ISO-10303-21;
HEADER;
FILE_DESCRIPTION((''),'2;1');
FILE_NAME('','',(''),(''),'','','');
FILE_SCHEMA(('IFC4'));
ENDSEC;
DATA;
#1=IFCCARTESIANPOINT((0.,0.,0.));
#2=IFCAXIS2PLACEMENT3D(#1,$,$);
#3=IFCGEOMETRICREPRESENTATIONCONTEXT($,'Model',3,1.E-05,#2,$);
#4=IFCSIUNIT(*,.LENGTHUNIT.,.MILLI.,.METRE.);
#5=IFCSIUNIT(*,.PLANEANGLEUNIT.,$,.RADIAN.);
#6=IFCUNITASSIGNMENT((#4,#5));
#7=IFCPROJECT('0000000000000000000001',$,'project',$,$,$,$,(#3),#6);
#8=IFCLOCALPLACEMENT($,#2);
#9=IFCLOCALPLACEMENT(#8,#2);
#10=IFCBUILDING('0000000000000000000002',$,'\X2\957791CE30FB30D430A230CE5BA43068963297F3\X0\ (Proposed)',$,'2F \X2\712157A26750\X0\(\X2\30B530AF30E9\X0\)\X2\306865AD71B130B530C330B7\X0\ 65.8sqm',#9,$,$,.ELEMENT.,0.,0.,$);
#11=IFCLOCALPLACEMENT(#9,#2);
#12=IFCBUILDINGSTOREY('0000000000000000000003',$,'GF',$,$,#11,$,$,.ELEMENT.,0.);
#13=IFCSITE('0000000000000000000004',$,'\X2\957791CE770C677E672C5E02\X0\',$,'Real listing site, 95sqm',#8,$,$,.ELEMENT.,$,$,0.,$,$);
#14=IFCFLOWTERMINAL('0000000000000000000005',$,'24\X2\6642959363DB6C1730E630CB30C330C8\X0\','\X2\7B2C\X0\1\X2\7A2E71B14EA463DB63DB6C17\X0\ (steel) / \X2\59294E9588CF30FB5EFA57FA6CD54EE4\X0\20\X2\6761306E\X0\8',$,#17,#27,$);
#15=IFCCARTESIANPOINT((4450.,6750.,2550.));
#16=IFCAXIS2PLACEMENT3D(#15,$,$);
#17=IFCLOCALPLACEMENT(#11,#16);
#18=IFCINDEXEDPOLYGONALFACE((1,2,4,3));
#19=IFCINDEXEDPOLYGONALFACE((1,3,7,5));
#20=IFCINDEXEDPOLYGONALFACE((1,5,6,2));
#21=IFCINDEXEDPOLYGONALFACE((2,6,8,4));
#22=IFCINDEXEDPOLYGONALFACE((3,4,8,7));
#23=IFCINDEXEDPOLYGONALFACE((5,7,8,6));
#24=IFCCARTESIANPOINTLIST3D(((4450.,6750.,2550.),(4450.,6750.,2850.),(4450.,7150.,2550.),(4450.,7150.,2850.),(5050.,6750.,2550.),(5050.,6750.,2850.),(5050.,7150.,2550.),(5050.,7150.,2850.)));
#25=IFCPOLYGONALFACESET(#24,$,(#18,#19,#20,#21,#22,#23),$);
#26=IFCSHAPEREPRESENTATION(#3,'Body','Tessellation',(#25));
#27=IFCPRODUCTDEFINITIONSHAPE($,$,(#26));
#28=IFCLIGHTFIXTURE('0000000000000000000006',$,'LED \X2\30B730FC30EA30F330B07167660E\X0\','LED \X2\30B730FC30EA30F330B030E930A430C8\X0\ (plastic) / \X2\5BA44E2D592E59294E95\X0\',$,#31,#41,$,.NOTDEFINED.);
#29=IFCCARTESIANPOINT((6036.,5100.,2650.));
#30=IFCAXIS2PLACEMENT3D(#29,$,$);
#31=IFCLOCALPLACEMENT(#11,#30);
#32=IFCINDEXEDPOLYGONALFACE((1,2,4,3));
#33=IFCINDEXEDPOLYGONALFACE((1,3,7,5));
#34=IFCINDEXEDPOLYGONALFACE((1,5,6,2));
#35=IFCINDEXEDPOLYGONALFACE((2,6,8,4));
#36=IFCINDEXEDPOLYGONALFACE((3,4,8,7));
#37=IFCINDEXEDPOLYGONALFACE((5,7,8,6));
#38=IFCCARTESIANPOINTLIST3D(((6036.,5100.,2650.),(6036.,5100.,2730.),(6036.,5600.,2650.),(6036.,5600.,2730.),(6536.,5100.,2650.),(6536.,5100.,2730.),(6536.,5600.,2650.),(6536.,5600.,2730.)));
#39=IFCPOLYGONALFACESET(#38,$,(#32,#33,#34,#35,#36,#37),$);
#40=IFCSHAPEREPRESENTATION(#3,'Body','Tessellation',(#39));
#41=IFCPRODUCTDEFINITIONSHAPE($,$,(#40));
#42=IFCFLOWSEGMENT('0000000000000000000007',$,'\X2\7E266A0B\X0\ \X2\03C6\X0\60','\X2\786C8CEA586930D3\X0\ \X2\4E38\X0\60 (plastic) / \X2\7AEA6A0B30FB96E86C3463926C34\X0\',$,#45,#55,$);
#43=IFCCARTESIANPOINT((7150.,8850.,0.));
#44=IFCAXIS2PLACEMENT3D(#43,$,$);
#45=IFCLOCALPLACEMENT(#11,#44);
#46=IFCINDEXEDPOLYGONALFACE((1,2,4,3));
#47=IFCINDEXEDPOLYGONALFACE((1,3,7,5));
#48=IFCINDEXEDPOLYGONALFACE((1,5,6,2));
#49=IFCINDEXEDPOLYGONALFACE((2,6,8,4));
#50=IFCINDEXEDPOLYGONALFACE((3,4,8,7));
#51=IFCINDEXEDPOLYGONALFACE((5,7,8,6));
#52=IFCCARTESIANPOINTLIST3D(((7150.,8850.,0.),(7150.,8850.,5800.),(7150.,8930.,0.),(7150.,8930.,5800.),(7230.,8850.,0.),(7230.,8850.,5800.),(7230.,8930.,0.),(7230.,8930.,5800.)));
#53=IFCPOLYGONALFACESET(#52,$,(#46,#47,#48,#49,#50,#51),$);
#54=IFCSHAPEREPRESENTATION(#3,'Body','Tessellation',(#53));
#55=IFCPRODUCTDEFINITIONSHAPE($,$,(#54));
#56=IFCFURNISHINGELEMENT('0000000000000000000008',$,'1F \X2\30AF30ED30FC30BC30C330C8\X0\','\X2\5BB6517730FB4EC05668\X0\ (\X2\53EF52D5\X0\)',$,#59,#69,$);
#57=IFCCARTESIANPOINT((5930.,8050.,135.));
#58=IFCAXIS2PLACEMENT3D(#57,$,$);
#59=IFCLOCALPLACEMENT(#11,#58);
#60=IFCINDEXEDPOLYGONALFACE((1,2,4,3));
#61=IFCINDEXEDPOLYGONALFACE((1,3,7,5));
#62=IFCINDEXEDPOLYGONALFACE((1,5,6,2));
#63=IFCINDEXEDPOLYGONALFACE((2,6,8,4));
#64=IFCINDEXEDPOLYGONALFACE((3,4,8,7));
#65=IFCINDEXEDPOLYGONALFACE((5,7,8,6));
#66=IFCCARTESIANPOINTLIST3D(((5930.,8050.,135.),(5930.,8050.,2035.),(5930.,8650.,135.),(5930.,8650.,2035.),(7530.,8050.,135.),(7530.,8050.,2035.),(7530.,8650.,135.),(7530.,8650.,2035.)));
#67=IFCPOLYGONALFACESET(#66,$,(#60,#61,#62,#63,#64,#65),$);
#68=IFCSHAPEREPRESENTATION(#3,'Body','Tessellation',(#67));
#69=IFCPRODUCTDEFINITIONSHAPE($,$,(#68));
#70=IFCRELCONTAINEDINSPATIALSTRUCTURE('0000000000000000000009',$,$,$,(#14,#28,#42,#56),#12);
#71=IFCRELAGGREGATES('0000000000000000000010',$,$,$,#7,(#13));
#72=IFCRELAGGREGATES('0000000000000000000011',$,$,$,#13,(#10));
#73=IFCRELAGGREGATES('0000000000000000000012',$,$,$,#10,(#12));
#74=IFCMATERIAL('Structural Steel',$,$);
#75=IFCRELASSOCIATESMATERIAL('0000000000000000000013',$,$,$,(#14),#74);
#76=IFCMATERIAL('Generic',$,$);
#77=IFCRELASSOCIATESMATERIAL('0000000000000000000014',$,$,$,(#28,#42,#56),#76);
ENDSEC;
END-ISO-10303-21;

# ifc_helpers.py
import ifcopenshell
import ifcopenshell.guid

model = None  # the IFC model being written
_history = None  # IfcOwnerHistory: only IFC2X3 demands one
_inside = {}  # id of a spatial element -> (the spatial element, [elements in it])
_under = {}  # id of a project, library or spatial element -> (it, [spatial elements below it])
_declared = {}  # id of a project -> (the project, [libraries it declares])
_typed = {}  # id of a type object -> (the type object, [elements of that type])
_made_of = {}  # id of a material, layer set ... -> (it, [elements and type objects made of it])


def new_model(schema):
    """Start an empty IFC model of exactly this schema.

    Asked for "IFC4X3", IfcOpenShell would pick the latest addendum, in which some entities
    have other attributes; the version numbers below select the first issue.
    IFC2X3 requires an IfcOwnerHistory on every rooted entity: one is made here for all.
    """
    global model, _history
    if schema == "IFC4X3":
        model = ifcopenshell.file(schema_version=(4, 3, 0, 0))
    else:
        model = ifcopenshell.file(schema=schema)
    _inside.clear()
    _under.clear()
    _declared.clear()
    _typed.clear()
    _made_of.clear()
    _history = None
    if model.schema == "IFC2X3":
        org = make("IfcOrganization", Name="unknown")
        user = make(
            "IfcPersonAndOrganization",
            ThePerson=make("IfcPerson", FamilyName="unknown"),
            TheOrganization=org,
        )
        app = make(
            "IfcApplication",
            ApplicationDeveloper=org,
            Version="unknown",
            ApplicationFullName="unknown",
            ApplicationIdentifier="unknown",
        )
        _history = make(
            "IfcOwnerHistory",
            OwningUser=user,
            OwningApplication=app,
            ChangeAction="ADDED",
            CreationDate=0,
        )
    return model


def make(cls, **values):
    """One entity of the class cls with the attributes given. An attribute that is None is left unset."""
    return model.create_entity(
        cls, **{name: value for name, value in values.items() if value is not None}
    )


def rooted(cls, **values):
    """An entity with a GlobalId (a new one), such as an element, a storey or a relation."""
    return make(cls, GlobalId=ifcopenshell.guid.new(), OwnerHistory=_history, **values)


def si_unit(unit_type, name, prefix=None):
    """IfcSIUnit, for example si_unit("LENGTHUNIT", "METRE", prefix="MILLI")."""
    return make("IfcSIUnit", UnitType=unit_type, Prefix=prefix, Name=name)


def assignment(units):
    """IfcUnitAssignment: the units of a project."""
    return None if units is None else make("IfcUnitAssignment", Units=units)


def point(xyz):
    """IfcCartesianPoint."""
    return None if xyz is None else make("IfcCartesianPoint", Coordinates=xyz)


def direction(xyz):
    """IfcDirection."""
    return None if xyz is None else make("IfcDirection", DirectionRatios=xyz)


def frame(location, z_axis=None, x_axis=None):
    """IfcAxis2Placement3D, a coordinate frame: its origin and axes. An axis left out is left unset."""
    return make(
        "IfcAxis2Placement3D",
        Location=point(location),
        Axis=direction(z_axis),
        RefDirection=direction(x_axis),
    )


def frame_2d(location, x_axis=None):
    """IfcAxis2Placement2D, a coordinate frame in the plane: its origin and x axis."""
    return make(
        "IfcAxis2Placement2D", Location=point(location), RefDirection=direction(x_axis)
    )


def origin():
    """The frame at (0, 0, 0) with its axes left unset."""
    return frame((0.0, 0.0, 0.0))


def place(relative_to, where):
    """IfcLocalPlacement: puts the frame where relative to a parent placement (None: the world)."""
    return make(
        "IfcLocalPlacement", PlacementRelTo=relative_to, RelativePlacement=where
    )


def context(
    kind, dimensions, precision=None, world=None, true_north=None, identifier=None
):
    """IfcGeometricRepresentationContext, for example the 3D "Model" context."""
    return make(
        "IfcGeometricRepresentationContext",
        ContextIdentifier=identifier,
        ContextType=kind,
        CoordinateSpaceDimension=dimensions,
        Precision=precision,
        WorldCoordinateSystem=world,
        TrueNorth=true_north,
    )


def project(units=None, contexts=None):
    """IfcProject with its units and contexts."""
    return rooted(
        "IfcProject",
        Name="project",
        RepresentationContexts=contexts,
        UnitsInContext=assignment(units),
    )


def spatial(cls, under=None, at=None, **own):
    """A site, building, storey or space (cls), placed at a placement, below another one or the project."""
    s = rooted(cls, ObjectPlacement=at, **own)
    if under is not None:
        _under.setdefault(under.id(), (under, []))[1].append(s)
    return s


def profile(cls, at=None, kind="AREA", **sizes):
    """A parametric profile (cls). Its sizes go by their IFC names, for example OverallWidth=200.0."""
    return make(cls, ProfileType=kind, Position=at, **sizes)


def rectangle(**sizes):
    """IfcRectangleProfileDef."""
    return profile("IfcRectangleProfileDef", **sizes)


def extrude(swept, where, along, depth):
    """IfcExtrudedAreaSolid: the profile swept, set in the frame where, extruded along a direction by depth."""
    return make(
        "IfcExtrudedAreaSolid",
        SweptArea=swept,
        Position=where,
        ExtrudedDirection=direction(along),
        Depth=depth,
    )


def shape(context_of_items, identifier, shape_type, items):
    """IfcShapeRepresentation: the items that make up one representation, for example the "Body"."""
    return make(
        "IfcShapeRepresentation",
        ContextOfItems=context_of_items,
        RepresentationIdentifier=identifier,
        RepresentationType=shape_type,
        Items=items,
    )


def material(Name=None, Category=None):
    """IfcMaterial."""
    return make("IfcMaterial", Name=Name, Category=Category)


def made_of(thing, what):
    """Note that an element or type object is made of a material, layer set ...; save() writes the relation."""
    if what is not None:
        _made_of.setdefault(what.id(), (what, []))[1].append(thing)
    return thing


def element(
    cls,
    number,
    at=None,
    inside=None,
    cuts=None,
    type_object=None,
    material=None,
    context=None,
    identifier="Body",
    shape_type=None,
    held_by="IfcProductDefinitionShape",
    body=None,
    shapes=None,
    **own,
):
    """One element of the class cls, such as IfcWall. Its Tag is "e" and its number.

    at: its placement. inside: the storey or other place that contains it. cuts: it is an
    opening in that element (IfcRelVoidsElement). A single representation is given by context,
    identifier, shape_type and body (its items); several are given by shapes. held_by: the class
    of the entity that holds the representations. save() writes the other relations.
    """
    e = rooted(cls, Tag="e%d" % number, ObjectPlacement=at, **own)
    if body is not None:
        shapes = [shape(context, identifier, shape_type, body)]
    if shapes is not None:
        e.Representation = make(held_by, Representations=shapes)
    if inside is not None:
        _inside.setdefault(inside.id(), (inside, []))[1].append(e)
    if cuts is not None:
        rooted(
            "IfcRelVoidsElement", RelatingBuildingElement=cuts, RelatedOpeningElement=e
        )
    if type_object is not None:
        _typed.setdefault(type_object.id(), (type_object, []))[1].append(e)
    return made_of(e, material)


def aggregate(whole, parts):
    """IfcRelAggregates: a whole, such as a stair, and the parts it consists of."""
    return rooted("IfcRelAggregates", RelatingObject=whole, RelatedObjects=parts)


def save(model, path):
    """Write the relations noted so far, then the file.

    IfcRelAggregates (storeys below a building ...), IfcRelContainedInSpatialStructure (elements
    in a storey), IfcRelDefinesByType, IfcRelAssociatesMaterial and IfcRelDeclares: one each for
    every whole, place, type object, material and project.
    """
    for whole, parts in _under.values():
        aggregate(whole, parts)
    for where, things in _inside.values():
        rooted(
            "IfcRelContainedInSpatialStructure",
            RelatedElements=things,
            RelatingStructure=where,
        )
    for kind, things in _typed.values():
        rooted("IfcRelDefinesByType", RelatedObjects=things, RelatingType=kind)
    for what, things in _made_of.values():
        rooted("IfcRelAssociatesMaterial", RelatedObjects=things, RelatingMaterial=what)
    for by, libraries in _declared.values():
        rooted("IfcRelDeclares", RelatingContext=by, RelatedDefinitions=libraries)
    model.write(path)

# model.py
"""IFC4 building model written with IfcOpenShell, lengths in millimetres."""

from ifc_helpers import new_model, si_unit, frame, frame_2d, origin, place, context, project, spatial, rectangle, extrude, material, element, save


model = new_model("IFC4")

# Units and contexts
model_context = context("Model", 3, precision=1e-05, world=origin())
ifc_project = project(units=[si_unit("LENGTHUNIT", "METRE", prefix="MILLI"), si_unit("PLANEANGLEUNIT", "RADIAN")], contexts=[model_context])

# Site, building, storey
site_placement = place(None, origin())
site = spatial("IfcSite", under=ifc_project, at=site_placement, Name="長野県松本市", ObjectType="Real listing site, 95sqm", CompositionType="ELEMENT", RefElevation=0.0)
building_placement = place(site_placement, origin())
building = spatial("IfcBuilding", under=site, at=building_placement, Name="長野・ピアノ室と防音 (Proposed)", ObjectType="2F 無垢材(サクラ)と断熱サッシ 65.8sqm", CompositionType="ELEMENT", ElevationOfRefHeight=0.0, ElevationOfTerrain=0.0)
storey_placement = place(building_placement, origin())
storey = spatial("IfcBuildingStorey", under=building, at=storey_placement, Name="GF", CompositionType="ELEMENT", Elevation=0.0)

# Shared definitions
ifc_material_1 = material(Name="Generic")

# Flow terminal
ifc_material_2 = material(Name="Structural Steel")
flow_terminal_placement = place(storey_placement, frame((4450.0, 6750.0, 2550.0)))
element("IfcFlowTerminal", 1, at=flow_terminal_placement, inside=storey, material=ifc_material_2, Name="24時間換気ユニット", Description="第1種熱交換換気 (steel) / 天井裏・建基法令20条の8", context=model_context, shape_type="SweptSolid", body=[
    extrude(rectangle(XDim=600.0, YDim=400.0, at=frame_2d((300.0, 200.0))), frame((4450.0, 6750.0, 2550.0)), (0.0, 0.0, 1.0), 300.0),
])

# Light fixture
light_fixture_placement = place(storey_placement, frame((6036.0, 5100.0, 2650.0)))
element("IfcLightFixture", 2, at=light_fixture_placement, inside=storey, material=ifc_material_1, Name="LED シーリング照明", Description="LED シーリングライト (plastic) / 室中央天井", PredefinedType="NOTDEFINED", context=model_context, shape_type="SweptSolid", body=[
    extrude(rectangle(XDim=500.0, YDim=500.0, at=frame_2d((250.0, 250.0))), frame((6036.0, 5100.0, 2650.0)), (0.0, 0.0, 1.0), 80.0),
])

# Flow segment
flow_segment_placement = place(storey_placement, frame((7150.0, 8850.0, 0.0)))
element("IfcFlowSegment", 3, at=flow_segment_placement, inside=storey, material=ifc_material_1, Name="縦樋 φ60", Description="硬質塩ビ 丸60 (plastic) / 竪樋・雨水排水", context=model_context, shape_type="SweptSolid", body=[
    extrude(rectangle(XDim=80.0, YDim=80.0, at=frame_2d((40.0, 40.0))), frame((7150.0, 8850.0, 0.0)), (0.0, 0.0, 1.0), 5800.0),
])

# Furnishing element
furnishing_placement = place(storey_placement, frame((5930.0, 8050.0, 135.0)))
element("IfcFurnishingElement", 4, at=furnishing_placement, inside=storey, material=ifc_material_1, Name="1F クローゼット", Description="家具・什器 (可動)", context=model_context, shape_type="SweptSolid", body=[
    extrude(rectangle(XDim=1600.0, YDim=600.0, at=frame_2d((800.0, 300.0))), frame((5930.0, 8050.0, 135.0)), (0.0, 0.0, 1.0), 1900.0),
])

save(model, "model.ifc")
